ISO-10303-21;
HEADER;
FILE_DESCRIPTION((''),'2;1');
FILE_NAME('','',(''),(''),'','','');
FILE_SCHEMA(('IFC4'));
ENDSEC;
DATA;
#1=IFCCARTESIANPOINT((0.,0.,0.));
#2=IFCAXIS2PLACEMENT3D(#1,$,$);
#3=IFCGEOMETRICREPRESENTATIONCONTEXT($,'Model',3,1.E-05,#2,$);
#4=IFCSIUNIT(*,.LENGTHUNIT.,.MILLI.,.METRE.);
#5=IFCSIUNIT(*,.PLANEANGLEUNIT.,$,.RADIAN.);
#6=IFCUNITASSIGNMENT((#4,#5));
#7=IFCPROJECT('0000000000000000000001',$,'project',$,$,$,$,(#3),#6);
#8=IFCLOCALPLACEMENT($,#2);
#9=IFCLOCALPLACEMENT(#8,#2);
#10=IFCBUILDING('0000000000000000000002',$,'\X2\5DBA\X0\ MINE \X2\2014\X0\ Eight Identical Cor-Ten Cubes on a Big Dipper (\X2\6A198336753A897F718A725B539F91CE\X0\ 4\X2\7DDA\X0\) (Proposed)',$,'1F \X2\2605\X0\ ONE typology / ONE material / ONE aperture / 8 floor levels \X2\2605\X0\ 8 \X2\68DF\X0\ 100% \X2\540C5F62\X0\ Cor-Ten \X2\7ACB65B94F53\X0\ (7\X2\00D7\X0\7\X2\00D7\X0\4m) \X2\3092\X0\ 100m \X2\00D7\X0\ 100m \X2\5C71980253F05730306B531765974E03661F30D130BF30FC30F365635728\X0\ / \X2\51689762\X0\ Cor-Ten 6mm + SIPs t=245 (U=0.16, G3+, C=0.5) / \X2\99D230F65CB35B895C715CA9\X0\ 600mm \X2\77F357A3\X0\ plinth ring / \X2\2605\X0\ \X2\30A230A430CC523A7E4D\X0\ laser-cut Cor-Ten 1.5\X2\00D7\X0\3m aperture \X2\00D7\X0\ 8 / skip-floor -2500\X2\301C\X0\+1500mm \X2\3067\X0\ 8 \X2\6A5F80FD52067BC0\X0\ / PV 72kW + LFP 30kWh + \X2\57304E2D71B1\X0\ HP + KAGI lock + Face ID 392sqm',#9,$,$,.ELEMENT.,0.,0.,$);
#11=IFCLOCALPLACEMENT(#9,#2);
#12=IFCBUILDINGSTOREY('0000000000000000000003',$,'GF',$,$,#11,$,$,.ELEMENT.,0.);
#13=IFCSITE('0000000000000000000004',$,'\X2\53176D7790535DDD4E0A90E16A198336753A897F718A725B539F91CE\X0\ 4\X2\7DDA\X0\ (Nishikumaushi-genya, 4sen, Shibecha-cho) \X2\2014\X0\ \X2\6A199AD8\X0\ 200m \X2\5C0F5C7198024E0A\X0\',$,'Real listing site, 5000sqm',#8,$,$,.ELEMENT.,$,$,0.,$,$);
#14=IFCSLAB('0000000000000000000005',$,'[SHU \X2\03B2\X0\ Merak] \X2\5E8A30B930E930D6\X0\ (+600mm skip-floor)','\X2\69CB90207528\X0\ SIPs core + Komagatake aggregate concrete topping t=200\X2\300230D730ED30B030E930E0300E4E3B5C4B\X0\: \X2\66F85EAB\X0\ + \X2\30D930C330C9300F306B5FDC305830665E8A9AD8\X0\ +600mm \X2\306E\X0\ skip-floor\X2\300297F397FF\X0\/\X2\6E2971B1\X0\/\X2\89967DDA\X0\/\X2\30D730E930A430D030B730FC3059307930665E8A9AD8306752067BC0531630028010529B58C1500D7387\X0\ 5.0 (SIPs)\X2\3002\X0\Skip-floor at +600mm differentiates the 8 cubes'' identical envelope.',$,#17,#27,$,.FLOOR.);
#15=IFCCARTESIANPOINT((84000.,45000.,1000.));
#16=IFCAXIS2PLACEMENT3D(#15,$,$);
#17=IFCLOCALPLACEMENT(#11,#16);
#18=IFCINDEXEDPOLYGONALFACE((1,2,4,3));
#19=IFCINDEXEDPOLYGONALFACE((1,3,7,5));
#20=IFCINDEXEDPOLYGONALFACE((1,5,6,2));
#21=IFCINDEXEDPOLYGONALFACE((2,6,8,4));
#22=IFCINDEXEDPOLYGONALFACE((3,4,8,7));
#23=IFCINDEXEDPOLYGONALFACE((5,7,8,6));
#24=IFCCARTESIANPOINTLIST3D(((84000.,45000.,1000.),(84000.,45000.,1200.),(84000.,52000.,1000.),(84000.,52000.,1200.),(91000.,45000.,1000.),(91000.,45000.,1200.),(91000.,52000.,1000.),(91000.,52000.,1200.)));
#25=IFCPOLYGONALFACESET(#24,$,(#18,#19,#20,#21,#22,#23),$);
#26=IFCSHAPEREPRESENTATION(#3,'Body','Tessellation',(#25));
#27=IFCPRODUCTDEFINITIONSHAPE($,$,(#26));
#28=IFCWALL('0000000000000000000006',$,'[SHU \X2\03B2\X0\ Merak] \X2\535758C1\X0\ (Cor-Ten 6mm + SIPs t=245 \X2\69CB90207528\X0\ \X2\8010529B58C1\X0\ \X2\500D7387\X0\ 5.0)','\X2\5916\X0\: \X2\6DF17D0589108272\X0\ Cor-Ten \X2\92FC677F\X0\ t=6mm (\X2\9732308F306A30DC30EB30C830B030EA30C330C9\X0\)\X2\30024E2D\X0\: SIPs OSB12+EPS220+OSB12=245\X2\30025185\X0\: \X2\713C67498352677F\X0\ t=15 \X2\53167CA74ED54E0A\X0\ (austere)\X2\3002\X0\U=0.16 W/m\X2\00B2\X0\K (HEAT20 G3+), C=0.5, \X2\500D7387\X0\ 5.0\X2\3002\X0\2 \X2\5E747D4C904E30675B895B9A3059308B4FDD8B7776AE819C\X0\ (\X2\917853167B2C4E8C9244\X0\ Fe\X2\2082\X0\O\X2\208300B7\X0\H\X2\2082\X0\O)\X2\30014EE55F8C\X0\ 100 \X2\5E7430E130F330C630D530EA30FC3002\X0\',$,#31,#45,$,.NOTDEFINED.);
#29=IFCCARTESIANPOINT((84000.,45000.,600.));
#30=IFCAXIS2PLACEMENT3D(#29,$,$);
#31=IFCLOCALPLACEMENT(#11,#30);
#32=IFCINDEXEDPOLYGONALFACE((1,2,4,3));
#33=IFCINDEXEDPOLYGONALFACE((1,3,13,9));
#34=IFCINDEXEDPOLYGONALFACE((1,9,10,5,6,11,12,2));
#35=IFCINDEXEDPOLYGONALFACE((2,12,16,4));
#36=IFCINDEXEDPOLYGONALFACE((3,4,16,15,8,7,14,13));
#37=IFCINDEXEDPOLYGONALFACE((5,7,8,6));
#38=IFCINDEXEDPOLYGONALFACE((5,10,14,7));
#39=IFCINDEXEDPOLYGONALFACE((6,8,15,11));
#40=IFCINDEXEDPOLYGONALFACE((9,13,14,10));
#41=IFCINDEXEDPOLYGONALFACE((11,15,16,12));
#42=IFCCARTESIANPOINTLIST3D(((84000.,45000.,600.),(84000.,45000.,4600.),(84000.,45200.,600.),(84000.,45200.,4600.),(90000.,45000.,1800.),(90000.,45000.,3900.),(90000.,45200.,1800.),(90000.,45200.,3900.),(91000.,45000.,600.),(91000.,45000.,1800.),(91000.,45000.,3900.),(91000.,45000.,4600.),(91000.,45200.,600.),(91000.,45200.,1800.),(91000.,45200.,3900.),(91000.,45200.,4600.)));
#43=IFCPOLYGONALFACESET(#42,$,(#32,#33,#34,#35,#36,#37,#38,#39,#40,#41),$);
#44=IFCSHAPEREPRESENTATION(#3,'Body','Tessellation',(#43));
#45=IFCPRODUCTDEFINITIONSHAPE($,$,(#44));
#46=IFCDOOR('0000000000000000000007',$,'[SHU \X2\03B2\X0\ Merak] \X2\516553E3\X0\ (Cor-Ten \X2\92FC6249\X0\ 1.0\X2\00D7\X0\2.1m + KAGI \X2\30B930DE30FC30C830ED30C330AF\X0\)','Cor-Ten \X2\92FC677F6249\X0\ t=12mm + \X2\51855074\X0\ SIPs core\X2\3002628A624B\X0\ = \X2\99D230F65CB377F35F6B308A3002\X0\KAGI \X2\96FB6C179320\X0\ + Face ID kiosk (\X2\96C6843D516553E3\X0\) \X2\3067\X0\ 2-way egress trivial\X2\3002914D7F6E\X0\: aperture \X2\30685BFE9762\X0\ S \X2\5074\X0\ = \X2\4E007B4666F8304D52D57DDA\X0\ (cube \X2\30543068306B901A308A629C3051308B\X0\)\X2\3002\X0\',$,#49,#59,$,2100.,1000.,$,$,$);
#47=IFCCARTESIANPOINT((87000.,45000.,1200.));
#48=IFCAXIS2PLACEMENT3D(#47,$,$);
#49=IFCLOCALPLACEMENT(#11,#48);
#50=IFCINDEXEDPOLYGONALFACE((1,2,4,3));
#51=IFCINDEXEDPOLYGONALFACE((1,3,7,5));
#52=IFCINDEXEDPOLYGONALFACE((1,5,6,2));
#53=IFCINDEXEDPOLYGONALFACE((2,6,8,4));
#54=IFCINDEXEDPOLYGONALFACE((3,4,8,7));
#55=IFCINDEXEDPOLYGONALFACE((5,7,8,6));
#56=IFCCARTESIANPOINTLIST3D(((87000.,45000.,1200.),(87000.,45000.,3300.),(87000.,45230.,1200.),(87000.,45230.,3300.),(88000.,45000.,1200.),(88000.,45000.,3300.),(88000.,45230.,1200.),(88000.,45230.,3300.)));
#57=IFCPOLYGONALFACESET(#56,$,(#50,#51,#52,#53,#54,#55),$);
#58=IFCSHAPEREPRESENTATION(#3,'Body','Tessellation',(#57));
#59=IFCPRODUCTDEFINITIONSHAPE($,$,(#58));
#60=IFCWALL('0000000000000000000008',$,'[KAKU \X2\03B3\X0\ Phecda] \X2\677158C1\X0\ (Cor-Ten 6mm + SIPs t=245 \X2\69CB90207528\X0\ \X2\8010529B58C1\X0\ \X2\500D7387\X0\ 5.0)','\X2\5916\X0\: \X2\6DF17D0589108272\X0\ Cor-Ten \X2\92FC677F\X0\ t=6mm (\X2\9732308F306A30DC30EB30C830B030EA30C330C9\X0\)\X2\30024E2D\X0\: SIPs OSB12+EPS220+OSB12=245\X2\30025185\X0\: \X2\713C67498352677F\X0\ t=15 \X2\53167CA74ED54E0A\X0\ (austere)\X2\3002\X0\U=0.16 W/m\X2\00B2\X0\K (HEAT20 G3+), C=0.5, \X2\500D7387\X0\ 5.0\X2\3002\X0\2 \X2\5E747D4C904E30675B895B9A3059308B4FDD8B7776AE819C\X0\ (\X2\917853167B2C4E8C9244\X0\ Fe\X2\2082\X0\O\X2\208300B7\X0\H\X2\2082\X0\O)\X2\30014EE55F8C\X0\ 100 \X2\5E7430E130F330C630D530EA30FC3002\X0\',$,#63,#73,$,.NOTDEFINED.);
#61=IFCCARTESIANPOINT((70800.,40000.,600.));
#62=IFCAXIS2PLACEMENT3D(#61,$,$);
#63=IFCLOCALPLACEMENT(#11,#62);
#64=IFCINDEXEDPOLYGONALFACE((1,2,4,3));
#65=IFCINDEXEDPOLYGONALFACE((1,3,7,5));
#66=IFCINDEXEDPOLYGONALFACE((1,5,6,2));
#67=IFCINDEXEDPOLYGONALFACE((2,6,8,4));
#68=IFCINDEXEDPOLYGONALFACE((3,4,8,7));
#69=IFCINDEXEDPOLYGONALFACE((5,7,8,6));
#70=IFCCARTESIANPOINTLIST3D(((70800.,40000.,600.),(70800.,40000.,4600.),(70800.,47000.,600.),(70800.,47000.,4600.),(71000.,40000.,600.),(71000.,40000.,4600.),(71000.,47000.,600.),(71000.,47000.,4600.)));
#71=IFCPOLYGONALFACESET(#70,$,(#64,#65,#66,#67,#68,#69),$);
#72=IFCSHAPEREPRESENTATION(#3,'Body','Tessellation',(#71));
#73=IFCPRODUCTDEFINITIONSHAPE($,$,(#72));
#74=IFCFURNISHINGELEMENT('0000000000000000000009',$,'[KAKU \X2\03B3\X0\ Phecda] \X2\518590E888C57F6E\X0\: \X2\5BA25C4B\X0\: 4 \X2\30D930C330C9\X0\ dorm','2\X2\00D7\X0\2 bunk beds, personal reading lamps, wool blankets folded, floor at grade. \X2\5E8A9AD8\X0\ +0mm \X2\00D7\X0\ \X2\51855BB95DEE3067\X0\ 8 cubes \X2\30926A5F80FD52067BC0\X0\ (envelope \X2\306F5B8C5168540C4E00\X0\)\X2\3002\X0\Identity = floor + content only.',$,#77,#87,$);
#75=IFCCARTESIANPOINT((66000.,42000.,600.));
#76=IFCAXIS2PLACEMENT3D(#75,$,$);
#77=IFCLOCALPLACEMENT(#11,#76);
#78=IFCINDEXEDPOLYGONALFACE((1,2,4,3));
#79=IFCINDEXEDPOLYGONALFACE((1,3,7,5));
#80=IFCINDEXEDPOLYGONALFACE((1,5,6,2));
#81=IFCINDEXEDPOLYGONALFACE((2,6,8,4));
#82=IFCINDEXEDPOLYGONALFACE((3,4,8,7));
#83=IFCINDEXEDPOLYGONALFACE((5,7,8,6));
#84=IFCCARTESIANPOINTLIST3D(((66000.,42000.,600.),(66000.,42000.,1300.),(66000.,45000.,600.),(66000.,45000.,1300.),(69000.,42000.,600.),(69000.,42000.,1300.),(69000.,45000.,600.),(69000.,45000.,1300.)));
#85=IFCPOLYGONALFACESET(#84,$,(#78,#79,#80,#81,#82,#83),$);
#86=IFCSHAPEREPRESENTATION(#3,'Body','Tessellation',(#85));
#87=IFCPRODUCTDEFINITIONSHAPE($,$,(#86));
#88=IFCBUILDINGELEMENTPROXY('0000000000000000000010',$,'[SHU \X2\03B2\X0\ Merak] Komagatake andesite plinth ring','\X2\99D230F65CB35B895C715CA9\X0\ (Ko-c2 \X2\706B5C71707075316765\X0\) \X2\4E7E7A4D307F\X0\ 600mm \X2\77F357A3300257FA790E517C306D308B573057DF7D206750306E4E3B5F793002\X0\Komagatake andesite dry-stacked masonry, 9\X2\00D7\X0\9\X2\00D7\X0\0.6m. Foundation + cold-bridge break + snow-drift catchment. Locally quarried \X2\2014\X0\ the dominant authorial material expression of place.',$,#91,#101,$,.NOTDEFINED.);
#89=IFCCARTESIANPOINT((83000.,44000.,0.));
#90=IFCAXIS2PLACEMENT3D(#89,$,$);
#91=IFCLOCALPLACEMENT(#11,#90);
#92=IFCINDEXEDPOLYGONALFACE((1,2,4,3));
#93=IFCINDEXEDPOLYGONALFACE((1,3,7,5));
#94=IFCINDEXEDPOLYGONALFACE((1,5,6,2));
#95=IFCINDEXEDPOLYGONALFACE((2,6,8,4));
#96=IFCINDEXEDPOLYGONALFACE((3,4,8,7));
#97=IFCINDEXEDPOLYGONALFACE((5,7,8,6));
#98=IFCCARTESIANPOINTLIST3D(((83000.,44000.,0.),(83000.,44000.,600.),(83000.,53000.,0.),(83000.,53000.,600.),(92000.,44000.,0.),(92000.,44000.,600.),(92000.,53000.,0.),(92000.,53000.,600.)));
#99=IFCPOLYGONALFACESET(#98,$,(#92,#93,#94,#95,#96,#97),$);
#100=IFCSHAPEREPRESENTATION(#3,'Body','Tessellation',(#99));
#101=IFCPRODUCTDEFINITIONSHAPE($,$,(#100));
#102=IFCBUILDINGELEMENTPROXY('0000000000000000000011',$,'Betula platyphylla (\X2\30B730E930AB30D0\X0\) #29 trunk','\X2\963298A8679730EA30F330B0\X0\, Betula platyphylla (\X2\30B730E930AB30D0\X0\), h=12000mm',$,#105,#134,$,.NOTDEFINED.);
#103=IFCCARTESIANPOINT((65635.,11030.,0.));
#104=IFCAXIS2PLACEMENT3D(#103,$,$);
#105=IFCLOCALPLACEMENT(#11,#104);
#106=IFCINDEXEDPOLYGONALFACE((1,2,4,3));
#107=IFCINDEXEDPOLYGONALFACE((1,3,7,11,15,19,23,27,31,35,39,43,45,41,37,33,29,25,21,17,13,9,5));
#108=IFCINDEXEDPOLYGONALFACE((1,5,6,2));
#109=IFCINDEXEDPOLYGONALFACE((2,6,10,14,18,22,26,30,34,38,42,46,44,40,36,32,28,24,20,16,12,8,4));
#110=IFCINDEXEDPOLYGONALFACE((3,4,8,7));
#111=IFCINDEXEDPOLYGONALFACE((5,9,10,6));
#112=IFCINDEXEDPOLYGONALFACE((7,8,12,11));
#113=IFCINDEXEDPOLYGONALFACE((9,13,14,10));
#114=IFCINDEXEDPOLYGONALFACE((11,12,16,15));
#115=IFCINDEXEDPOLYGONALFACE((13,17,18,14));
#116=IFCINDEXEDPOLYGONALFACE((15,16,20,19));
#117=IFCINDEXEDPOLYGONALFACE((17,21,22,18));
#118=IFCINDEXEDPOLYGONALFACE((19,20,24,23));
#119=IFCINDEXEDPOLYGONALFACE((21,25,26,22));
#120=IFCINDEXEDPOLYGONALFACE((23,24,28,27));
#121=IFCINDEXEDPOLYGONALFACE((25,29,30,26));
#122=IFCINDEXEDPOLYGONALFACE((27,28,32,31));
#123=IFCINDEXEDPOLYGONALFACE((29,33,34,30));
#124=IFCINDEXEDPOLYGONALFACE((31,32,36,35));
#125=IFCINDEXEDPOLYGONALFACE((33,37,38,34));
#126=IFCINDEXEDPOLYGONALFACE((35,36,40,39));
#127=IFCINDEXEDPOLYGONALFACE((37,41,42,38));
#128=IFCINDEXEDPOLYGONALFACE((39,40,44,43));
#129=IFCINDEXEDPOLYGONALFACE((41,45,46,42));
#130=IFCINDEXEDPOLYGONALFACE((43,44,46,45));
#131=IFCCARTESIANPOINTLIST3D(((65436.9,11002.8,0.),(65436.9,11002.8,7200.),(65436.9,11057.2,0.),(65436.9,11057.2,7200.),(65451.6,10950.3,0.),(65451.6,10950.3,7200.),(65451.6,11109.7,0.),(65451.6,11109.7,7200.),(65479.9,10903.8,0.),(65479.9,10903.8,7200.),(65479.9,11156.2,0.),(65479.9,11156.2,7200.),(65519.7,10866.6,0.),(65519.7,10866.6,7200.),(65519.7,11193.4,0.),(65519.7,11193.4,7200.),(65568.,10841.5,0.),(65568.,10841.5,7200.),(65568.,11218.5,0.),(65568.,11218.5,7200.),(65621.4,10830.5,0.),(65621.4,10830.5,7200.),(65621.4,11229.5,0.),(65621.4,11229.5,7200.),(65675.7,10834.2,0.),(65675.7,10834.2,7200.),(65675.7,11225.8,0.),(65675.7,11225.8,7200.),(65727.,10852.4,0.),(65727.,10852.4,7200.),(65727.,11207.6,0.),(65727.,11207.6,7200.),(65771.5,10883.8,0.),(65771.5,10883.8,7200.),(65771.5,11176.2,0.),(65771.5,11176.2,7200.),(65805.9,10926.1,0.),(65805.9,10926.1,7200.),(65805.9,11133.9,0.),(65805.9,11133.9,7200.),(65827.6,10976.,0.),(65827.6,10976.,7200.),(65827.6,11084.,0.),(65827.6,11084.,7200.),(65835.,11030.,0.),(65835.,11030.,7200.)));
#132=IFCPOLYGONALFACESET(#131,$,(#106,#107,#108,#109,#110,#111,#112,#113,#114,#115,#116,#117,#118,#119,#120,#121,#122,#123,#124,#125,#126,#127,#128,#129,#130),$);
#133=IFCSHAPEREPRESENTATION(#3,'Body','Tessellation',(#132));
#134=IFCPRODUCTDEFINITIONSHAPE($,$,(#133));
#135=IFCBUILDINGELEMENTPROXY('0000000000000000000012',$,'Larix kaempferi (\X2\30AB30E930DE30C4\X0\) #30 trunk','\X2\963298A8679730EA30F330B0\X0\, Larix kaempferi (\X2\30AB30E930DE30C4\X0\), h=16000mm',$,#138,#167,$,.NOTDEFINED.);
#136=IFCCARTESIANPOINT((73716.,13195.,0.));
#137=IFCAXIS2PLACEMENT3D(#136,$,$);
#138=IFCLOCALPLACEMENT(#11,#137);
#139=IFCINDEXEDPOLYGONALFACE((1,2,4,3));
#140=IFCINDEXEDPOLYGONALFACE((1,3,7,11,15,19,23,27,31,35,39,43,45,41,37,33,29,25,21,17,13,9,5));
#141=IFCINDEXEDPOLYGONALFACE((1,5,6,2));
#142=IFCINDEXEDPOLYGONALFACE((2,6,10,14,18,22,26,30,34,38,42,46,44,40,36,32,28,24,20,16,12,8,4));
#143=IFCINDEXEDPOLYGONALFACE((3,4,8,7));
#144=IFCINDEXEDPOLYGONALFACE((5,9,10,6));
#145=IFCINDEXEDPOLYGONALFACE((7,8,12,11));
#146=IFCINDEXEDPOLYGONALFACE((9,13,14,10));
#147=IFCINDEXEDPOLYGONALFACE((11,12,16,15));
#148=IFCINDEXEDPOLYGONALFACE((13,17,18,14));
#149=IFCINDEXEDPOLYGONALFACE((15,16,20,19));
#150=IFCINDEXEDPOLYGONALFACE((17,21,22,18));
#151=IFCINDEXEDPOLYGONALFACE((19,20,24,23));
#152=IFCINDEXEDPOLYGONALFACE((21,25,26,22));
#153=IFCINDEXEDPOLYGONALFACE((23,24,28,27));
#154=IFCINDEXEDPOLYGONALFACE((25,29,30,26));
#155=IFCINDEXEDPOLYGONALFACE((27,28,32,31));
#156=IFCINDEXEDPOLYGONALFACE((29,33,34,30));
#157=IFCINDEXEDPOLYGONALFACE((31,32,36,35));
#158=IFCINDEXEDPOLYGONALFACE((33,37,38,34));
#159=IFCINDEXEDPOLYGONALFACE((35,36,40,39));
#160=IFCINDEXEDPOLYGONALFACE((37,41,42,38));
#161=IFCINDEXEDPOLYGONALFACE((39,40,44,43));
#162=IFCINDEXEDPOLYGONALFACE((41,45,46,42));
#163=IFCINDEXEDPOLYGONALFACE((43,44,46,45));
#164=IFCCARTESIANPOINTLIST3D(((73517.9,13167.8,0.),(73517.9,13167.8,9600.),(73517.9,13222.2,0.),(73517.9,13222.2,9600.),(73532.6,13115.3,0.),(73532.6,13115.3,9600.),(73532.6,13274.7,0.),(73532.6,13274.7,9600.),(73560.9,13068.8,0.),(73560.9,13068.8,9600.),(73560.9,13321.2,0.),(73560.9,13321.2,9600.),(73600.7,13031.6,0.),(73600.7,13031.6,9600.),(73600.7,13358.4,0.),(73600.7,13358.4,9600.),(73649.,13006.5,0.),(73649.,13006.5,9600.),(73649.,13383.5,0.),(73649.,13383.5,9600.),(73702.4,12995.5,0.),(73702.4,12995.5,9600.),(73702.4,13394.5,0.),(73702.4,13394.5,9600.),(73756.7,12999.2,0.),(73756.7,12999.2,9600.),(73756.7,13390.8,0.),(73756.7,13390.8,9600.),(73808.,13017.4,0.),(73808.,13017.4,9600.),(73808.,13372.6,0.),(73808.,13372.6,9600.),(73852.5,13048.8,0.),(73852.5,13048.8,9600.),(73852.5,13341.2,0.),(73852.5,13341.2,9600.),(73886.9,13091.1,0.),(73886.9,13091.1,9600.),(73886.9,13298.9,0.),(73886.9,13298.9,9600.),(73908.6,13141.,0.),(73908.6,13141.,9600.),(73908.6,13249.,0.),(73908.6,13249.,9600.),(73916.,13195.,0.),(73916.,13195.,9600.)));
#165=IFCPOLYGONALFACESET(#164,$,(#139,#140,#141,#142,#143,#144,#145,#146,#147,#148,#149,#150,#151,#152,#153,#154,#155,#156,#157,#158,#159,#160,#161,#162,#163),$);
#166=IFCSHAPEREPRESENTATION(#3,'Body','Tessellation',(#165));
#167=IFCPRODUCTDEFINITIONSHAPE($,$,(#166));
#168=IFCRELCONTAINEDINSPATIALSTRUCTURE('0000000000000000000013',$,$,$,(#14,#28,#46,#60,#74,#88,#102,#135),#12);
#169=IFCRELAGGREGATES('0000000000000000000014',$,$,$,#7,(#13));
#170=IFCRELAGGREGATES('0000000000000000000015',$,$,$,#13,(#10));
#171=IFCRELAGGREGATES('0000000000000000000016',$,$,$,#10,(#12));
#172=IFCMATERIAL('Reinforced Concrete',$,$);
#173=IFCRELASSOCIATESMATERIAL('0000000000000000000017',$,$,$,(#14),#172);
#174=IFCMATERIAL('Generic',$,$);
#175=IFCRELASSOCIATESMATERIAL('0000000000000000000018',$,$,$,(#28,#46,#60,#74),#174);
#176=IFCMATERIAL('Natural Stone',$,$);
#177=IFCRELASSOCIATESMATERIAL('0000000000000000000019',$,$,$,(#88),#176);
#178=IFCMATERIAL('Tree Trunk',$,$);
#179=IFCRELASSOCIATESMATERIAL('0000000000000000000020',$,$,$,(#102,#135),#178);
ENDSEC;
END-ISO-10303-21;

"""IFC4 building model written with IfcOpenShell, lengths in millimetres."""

from ifc_helpers import new_model, si_unit, frame, frame_2d, origin, origin_2d, place, context, project, spatial, rectangle, circle, extrude, material, element, fill, save


model = new_model("IFC4")

# Units and contexts
model_context = context("Model", 3, precision=1e-05, world=origin())
ifc_project = project(units=[si_unit("LENGTHUNIT", "METRE", prefix="MILLI"), si_unit("PLANEANGLEUNIT", "RADIAN")], contexts=[model_context])

# Site, building, storey
site_placement = place(None, origin())
site = spatial("IfcSite", under=ifc_project, at=site_placement, Name="北海道川上郡標茶町西熊牛原野 4線 (Nishikumaushi-genya, 4sen, Shibecha-cho) — 標高 200m 小山頂上", ObjectType="Real listing site, 5000sqm", CompositionType="ELEMENT", RefElevation=0.0)
building_placement = place(site_placement, origin())
building = spatial("IfcBuilding", under=site, at=building_placement, Name="嶺 MINE — Eight Identical Cor-Ten Cubes on a Big Dipper (標茶町西熊牛原野 4線) (Proposed)", ObjectType="1F ★ ONE typology / ONE material / ONE aperture / 8 floor levels ★ 8 棟 100% 同形 Cor-Ten 立方体 (7×7×4m) を 100m × 100m 山頂台地に北斗七星パターン散在 / 全面 Cor-Ten 6mm + SIPs t=245 (U=0.16, G3+, C=0.5) / 駒ヶ岳安山岩 600mm 石垣 plinth ring / ★ アイヌ刺繍 laser-cut Cor-Ten 1.5×3m aperture × 8 / skip-floor -2500〜+1500mm で 8 機能分節 / PV 72kW + LFP 30kWh + 地中熱 HP + KAGI lock + Face ID 392sqm", CompositionType="ELEMENT", ElevationOfRefHeight=0.0, ElevationOfTerrain=0.0)
storey_placement = place(building_placement, origin())
storey = spatial("IfcBuildingStorey", under=building, at=storey_placement, Name="GF", CompositionType="ELEMENT", Elevation=0.0)

# Slab
ifc_material_1 = material(Name="Reinforced Concrete")
slab_placement = place(storey_placement, frame((84000.0, 45000.0, 1000.0)))
element("IfcSlab", 1, at=slab_placement, inside=storey, material=ifc_material_1, Name="[SHU β Merak] 床スラブ (+600mm skip-floor)", Description="構造用 SIPs core + Komagatake aggregate concrete topping t=200。プログラム『主屋: 書庫 + ベッド』に応じて床高 +600mm の skip-floor。音響/温熱/視線/プライバシーすべて床高で分節化。耐力壁倍率 5.0 (SIPs)。Skip-floor at +600mm differentiates the 8 cubes' identical envelope.", PredefinedType="FLOOR", context=model_context, shape_type="SweptSolid", body=[
    extrude(rectangle(XDim=7000.0, YDim=7000.0, at=frame_2d((3500.0, 3500.0))), frame((84000.0, 45000.0, 1000.0)), (0.0, 0.0, 1.0), 200.0),
])

# Wall, opening, door
ifc_material_2 = material(Name="Generic")
wall_1_placement = place(storey_placement, frame((84000.0, 45000.0, 600.0)))
wall_1 = element("IfcWall", 2, at=wall_1_placement, inside=storey, material=ifc_material_2, Name="[SHU β Merak] 南壁 (Cor-Ten 6mm + SIPs t=245 構造用 耐力壁 倍率 5.0)", Description="外: 深紅褐色 Cor-Ten 鋼板 t=6mm (露わなボルトグリッド)。中: SIPs OSB12+EPS220+OSB12=245。内: 焼杉荒板 t=15 化粧仕上 (austere)。U=0.16 W/m²K (HEAT20 G3+), C=0.5, 倍率 5.0。2 年経過で安定する保護皮膜 (酸化第二鉄 Fe₂O₃·H₂O)、以後 100 年メンテフリー。", PredefinedType="NOTDEFINED", context=model_context, shape_type="SweptSolid", body=[
    extrude(rectangle(XDim=7000.0, YDim=200.0, at=frame_2d((3500.0, 100.0))), frame((84000.0, 45000.0, 600.0)), (0.0, 0.0, 1.0), 4000.0),
])
opening_placement = place(storey_placement, frame((87000.0, 45000.0, 1200.0)))
opening = element("IfcOpeningElement", 3, at=opening_placement, cuts=wall_1, PredefinedType="NOTDEFINED", context=model_context, shape_type="SweptSolid", body=[
    extrude(rectangle(XDim=1000.0, YDim=230.0, at=frame_2d((500.0, 115.0))), frame((87000.0, 45000.0, 1200.0)), (0.0, 0.0, 1.0), 2100.0),
])
door_placement = place(storey_placement, frame((87000.0, 45000.0, 1200.0)))
door = element("IfcDoor", 4, at=door_placement, inside=storey, material=ifc_material_2, Name="[SHU β Merak] 入口 (Cor-Ten 鋼扉 1.0×2.1m + KAGI スマートロック)", Description="Cor-Ten 鋼板扉 t=12mm + 内側 SIPs core。把手 = 駒ヶ岳石彫り。KAGI 電気錠 + Face ID kiosk (集落入口) で 2-way egress trivial。配置: aperture と対面 S 側 = 一筆書き動線 (cube ごとに通り抜ける)。", OverallHeight=2100.0, OverallWidth=1000.0, context=model_context, shape_type="SweptSolid", body=[
    extrude(rectangle(XDim=1000.0, YDim=230.0, at=frame_2d((500.0, 115.0))), frame((87000.0, 45000.0, 1200.0)), (0.0, 0.0, 1.0), 2100.0),
])
fill(opening, door)

# Wall
wall_2_placement = place(storey_placement, frame((70800.0, 40000.0, 600.0)))
element("IfcWall", 5, at=wall_2_placement, inside=storey, material=ifc_material_2, Name="[KAKU γ Phecda] 東壁 (Cor-Ten 6mm + SIPs t=245 構造用 耐力壁 倍率 5.0)", Description="外: 深紅褐色 Cor-Ten 鋼板 t=6mm (露わなボルトグリッド)。中: SIPs OSB12+EPS220+OSB12=245。内: 焼杉荒板 t=15 化粧仕上 (austere)。U=0.16 W/m²K (HEAT20 G3+), C=0.5, 倍率 5.0。2 年経過で安定する保護皮膜 (酸化第二鉄 Fe₂O₃·H₂O)、以後 100 年メンテフリー。", PredefinedType="NOTDEFINED", context=model_context, shape_type="SweptSolid", body=[
    extrude(rectangle(XDim=200.0, YDim=7000.0, at=frame_2d((100.0, 3500.0))), frame((70800.0, 40000.0, 600.0)), (0.0, 0.0, 1.0), 4000.0),
])

# Furnishing element
furnishing_placement = place(storey_placement, frame((66000.0, 42000.0, 600.0)))
element("IfcFurnishingElement", 6, at=furnishing_placement, inside=storey, material=ifc_material_2, Name="[KAKU γ Phecda] 内部装置: 客屋: 4 ベッド dorm", Description="2×2 bunk beds, personal reading lamps, wool blankets folded, floor at grade. 床高 +0mm × 内容差で 8 cubes を機能分節 (envelope は完全同一)。Identity = floor + content only.", context=model_context, shape_type="SweptSolid", body=[
    extrude(rectangle(XDim=3000.0, YDim=3000.0, at=frame_2d((1500.0, 1500.0))), frame((66000.0, 42000.0, 600.0)), (0.0, 0.0, 1.0), 700.0),
])

# Building element proxies
ifc_material_3 = material(Name="Natural Stone")
proxy_1_placement = place(storey_placement, frame((83000.0, 44000.0, 0.0)))
element("IfcBuildingElementProxy", 7, at=proxy_1_placement, inside=storey, material=ifc_material_3, Name="[SHU β Merak] Komagatake andesite plinth ring", Description="駒ヶ岳安山岩 (Ko-c2 火山灰由来) 乾積み 600mm 石垣。基礎兼ねる地域素材の主役。Komagatake andesite dry-stacked masonry, 9×9×0.6m. Foundation + cold-bridge break + snow-drift catchment. Locally quarried — the dominant authorial material expression of place.", PredefinedType="NOTDEFINED", context=model_context, shape_type="SweptSolid", body=[
    extrude(rectangle(XDim=9000.0, YDim=9000.0, at=frame_2d((4500.0, 4500.0))), frame((83000.0, 44000.0, 0.0)), (0.0, 0.0, 1.0), 600.0),
])
ifc_material_4 = material(Name="Tree Trunk")
proxy_2_placement = place(storey_placement, frame((65635.0, 11030.0, 0.0)))
element("IfcBuildingElementProxy", 8, at=proxy_2_placement, inside=storey, material=ifc_material_4, Name="Betula platyphylla (シラカバ) #29 trunk", Description="防風林リング, Betula platyphylla (シラカバ), h=12000mm", PredefinedType="NOTDEFINED", context=model_context, shape_type="SweptSolid", body=[
    extrude(circle(Radius=200.0, at=origin_2d()), frame((65635.0, 11030.0, 0.0)), (0.0, 0.0, 1.0), 7200.0),
])
proxy_3_placement = place(storey_placement, frame((73716.0, 13195.0, 0.0)))
element("IfcBuildingElementProxy", 9, at=proxy_3_placement, inside=storey, material=ifc_material_4, Name="Larix kaempferi (カラマツ) #30 trunk", Description="防風林リング, Larix kaempferi (カラマツ), h=16000mm", PredefinedType="NOTDEFINED", context=model_context, shape_type="SweptSolid", body=[
    extrude(circle(Radius=200.0, at=origin_2d()), frame((73716.0, 13195.0, 0.0)), (0.0, 0.0, 1.0), 9600.0),
])

save(model, "model.ifc")
